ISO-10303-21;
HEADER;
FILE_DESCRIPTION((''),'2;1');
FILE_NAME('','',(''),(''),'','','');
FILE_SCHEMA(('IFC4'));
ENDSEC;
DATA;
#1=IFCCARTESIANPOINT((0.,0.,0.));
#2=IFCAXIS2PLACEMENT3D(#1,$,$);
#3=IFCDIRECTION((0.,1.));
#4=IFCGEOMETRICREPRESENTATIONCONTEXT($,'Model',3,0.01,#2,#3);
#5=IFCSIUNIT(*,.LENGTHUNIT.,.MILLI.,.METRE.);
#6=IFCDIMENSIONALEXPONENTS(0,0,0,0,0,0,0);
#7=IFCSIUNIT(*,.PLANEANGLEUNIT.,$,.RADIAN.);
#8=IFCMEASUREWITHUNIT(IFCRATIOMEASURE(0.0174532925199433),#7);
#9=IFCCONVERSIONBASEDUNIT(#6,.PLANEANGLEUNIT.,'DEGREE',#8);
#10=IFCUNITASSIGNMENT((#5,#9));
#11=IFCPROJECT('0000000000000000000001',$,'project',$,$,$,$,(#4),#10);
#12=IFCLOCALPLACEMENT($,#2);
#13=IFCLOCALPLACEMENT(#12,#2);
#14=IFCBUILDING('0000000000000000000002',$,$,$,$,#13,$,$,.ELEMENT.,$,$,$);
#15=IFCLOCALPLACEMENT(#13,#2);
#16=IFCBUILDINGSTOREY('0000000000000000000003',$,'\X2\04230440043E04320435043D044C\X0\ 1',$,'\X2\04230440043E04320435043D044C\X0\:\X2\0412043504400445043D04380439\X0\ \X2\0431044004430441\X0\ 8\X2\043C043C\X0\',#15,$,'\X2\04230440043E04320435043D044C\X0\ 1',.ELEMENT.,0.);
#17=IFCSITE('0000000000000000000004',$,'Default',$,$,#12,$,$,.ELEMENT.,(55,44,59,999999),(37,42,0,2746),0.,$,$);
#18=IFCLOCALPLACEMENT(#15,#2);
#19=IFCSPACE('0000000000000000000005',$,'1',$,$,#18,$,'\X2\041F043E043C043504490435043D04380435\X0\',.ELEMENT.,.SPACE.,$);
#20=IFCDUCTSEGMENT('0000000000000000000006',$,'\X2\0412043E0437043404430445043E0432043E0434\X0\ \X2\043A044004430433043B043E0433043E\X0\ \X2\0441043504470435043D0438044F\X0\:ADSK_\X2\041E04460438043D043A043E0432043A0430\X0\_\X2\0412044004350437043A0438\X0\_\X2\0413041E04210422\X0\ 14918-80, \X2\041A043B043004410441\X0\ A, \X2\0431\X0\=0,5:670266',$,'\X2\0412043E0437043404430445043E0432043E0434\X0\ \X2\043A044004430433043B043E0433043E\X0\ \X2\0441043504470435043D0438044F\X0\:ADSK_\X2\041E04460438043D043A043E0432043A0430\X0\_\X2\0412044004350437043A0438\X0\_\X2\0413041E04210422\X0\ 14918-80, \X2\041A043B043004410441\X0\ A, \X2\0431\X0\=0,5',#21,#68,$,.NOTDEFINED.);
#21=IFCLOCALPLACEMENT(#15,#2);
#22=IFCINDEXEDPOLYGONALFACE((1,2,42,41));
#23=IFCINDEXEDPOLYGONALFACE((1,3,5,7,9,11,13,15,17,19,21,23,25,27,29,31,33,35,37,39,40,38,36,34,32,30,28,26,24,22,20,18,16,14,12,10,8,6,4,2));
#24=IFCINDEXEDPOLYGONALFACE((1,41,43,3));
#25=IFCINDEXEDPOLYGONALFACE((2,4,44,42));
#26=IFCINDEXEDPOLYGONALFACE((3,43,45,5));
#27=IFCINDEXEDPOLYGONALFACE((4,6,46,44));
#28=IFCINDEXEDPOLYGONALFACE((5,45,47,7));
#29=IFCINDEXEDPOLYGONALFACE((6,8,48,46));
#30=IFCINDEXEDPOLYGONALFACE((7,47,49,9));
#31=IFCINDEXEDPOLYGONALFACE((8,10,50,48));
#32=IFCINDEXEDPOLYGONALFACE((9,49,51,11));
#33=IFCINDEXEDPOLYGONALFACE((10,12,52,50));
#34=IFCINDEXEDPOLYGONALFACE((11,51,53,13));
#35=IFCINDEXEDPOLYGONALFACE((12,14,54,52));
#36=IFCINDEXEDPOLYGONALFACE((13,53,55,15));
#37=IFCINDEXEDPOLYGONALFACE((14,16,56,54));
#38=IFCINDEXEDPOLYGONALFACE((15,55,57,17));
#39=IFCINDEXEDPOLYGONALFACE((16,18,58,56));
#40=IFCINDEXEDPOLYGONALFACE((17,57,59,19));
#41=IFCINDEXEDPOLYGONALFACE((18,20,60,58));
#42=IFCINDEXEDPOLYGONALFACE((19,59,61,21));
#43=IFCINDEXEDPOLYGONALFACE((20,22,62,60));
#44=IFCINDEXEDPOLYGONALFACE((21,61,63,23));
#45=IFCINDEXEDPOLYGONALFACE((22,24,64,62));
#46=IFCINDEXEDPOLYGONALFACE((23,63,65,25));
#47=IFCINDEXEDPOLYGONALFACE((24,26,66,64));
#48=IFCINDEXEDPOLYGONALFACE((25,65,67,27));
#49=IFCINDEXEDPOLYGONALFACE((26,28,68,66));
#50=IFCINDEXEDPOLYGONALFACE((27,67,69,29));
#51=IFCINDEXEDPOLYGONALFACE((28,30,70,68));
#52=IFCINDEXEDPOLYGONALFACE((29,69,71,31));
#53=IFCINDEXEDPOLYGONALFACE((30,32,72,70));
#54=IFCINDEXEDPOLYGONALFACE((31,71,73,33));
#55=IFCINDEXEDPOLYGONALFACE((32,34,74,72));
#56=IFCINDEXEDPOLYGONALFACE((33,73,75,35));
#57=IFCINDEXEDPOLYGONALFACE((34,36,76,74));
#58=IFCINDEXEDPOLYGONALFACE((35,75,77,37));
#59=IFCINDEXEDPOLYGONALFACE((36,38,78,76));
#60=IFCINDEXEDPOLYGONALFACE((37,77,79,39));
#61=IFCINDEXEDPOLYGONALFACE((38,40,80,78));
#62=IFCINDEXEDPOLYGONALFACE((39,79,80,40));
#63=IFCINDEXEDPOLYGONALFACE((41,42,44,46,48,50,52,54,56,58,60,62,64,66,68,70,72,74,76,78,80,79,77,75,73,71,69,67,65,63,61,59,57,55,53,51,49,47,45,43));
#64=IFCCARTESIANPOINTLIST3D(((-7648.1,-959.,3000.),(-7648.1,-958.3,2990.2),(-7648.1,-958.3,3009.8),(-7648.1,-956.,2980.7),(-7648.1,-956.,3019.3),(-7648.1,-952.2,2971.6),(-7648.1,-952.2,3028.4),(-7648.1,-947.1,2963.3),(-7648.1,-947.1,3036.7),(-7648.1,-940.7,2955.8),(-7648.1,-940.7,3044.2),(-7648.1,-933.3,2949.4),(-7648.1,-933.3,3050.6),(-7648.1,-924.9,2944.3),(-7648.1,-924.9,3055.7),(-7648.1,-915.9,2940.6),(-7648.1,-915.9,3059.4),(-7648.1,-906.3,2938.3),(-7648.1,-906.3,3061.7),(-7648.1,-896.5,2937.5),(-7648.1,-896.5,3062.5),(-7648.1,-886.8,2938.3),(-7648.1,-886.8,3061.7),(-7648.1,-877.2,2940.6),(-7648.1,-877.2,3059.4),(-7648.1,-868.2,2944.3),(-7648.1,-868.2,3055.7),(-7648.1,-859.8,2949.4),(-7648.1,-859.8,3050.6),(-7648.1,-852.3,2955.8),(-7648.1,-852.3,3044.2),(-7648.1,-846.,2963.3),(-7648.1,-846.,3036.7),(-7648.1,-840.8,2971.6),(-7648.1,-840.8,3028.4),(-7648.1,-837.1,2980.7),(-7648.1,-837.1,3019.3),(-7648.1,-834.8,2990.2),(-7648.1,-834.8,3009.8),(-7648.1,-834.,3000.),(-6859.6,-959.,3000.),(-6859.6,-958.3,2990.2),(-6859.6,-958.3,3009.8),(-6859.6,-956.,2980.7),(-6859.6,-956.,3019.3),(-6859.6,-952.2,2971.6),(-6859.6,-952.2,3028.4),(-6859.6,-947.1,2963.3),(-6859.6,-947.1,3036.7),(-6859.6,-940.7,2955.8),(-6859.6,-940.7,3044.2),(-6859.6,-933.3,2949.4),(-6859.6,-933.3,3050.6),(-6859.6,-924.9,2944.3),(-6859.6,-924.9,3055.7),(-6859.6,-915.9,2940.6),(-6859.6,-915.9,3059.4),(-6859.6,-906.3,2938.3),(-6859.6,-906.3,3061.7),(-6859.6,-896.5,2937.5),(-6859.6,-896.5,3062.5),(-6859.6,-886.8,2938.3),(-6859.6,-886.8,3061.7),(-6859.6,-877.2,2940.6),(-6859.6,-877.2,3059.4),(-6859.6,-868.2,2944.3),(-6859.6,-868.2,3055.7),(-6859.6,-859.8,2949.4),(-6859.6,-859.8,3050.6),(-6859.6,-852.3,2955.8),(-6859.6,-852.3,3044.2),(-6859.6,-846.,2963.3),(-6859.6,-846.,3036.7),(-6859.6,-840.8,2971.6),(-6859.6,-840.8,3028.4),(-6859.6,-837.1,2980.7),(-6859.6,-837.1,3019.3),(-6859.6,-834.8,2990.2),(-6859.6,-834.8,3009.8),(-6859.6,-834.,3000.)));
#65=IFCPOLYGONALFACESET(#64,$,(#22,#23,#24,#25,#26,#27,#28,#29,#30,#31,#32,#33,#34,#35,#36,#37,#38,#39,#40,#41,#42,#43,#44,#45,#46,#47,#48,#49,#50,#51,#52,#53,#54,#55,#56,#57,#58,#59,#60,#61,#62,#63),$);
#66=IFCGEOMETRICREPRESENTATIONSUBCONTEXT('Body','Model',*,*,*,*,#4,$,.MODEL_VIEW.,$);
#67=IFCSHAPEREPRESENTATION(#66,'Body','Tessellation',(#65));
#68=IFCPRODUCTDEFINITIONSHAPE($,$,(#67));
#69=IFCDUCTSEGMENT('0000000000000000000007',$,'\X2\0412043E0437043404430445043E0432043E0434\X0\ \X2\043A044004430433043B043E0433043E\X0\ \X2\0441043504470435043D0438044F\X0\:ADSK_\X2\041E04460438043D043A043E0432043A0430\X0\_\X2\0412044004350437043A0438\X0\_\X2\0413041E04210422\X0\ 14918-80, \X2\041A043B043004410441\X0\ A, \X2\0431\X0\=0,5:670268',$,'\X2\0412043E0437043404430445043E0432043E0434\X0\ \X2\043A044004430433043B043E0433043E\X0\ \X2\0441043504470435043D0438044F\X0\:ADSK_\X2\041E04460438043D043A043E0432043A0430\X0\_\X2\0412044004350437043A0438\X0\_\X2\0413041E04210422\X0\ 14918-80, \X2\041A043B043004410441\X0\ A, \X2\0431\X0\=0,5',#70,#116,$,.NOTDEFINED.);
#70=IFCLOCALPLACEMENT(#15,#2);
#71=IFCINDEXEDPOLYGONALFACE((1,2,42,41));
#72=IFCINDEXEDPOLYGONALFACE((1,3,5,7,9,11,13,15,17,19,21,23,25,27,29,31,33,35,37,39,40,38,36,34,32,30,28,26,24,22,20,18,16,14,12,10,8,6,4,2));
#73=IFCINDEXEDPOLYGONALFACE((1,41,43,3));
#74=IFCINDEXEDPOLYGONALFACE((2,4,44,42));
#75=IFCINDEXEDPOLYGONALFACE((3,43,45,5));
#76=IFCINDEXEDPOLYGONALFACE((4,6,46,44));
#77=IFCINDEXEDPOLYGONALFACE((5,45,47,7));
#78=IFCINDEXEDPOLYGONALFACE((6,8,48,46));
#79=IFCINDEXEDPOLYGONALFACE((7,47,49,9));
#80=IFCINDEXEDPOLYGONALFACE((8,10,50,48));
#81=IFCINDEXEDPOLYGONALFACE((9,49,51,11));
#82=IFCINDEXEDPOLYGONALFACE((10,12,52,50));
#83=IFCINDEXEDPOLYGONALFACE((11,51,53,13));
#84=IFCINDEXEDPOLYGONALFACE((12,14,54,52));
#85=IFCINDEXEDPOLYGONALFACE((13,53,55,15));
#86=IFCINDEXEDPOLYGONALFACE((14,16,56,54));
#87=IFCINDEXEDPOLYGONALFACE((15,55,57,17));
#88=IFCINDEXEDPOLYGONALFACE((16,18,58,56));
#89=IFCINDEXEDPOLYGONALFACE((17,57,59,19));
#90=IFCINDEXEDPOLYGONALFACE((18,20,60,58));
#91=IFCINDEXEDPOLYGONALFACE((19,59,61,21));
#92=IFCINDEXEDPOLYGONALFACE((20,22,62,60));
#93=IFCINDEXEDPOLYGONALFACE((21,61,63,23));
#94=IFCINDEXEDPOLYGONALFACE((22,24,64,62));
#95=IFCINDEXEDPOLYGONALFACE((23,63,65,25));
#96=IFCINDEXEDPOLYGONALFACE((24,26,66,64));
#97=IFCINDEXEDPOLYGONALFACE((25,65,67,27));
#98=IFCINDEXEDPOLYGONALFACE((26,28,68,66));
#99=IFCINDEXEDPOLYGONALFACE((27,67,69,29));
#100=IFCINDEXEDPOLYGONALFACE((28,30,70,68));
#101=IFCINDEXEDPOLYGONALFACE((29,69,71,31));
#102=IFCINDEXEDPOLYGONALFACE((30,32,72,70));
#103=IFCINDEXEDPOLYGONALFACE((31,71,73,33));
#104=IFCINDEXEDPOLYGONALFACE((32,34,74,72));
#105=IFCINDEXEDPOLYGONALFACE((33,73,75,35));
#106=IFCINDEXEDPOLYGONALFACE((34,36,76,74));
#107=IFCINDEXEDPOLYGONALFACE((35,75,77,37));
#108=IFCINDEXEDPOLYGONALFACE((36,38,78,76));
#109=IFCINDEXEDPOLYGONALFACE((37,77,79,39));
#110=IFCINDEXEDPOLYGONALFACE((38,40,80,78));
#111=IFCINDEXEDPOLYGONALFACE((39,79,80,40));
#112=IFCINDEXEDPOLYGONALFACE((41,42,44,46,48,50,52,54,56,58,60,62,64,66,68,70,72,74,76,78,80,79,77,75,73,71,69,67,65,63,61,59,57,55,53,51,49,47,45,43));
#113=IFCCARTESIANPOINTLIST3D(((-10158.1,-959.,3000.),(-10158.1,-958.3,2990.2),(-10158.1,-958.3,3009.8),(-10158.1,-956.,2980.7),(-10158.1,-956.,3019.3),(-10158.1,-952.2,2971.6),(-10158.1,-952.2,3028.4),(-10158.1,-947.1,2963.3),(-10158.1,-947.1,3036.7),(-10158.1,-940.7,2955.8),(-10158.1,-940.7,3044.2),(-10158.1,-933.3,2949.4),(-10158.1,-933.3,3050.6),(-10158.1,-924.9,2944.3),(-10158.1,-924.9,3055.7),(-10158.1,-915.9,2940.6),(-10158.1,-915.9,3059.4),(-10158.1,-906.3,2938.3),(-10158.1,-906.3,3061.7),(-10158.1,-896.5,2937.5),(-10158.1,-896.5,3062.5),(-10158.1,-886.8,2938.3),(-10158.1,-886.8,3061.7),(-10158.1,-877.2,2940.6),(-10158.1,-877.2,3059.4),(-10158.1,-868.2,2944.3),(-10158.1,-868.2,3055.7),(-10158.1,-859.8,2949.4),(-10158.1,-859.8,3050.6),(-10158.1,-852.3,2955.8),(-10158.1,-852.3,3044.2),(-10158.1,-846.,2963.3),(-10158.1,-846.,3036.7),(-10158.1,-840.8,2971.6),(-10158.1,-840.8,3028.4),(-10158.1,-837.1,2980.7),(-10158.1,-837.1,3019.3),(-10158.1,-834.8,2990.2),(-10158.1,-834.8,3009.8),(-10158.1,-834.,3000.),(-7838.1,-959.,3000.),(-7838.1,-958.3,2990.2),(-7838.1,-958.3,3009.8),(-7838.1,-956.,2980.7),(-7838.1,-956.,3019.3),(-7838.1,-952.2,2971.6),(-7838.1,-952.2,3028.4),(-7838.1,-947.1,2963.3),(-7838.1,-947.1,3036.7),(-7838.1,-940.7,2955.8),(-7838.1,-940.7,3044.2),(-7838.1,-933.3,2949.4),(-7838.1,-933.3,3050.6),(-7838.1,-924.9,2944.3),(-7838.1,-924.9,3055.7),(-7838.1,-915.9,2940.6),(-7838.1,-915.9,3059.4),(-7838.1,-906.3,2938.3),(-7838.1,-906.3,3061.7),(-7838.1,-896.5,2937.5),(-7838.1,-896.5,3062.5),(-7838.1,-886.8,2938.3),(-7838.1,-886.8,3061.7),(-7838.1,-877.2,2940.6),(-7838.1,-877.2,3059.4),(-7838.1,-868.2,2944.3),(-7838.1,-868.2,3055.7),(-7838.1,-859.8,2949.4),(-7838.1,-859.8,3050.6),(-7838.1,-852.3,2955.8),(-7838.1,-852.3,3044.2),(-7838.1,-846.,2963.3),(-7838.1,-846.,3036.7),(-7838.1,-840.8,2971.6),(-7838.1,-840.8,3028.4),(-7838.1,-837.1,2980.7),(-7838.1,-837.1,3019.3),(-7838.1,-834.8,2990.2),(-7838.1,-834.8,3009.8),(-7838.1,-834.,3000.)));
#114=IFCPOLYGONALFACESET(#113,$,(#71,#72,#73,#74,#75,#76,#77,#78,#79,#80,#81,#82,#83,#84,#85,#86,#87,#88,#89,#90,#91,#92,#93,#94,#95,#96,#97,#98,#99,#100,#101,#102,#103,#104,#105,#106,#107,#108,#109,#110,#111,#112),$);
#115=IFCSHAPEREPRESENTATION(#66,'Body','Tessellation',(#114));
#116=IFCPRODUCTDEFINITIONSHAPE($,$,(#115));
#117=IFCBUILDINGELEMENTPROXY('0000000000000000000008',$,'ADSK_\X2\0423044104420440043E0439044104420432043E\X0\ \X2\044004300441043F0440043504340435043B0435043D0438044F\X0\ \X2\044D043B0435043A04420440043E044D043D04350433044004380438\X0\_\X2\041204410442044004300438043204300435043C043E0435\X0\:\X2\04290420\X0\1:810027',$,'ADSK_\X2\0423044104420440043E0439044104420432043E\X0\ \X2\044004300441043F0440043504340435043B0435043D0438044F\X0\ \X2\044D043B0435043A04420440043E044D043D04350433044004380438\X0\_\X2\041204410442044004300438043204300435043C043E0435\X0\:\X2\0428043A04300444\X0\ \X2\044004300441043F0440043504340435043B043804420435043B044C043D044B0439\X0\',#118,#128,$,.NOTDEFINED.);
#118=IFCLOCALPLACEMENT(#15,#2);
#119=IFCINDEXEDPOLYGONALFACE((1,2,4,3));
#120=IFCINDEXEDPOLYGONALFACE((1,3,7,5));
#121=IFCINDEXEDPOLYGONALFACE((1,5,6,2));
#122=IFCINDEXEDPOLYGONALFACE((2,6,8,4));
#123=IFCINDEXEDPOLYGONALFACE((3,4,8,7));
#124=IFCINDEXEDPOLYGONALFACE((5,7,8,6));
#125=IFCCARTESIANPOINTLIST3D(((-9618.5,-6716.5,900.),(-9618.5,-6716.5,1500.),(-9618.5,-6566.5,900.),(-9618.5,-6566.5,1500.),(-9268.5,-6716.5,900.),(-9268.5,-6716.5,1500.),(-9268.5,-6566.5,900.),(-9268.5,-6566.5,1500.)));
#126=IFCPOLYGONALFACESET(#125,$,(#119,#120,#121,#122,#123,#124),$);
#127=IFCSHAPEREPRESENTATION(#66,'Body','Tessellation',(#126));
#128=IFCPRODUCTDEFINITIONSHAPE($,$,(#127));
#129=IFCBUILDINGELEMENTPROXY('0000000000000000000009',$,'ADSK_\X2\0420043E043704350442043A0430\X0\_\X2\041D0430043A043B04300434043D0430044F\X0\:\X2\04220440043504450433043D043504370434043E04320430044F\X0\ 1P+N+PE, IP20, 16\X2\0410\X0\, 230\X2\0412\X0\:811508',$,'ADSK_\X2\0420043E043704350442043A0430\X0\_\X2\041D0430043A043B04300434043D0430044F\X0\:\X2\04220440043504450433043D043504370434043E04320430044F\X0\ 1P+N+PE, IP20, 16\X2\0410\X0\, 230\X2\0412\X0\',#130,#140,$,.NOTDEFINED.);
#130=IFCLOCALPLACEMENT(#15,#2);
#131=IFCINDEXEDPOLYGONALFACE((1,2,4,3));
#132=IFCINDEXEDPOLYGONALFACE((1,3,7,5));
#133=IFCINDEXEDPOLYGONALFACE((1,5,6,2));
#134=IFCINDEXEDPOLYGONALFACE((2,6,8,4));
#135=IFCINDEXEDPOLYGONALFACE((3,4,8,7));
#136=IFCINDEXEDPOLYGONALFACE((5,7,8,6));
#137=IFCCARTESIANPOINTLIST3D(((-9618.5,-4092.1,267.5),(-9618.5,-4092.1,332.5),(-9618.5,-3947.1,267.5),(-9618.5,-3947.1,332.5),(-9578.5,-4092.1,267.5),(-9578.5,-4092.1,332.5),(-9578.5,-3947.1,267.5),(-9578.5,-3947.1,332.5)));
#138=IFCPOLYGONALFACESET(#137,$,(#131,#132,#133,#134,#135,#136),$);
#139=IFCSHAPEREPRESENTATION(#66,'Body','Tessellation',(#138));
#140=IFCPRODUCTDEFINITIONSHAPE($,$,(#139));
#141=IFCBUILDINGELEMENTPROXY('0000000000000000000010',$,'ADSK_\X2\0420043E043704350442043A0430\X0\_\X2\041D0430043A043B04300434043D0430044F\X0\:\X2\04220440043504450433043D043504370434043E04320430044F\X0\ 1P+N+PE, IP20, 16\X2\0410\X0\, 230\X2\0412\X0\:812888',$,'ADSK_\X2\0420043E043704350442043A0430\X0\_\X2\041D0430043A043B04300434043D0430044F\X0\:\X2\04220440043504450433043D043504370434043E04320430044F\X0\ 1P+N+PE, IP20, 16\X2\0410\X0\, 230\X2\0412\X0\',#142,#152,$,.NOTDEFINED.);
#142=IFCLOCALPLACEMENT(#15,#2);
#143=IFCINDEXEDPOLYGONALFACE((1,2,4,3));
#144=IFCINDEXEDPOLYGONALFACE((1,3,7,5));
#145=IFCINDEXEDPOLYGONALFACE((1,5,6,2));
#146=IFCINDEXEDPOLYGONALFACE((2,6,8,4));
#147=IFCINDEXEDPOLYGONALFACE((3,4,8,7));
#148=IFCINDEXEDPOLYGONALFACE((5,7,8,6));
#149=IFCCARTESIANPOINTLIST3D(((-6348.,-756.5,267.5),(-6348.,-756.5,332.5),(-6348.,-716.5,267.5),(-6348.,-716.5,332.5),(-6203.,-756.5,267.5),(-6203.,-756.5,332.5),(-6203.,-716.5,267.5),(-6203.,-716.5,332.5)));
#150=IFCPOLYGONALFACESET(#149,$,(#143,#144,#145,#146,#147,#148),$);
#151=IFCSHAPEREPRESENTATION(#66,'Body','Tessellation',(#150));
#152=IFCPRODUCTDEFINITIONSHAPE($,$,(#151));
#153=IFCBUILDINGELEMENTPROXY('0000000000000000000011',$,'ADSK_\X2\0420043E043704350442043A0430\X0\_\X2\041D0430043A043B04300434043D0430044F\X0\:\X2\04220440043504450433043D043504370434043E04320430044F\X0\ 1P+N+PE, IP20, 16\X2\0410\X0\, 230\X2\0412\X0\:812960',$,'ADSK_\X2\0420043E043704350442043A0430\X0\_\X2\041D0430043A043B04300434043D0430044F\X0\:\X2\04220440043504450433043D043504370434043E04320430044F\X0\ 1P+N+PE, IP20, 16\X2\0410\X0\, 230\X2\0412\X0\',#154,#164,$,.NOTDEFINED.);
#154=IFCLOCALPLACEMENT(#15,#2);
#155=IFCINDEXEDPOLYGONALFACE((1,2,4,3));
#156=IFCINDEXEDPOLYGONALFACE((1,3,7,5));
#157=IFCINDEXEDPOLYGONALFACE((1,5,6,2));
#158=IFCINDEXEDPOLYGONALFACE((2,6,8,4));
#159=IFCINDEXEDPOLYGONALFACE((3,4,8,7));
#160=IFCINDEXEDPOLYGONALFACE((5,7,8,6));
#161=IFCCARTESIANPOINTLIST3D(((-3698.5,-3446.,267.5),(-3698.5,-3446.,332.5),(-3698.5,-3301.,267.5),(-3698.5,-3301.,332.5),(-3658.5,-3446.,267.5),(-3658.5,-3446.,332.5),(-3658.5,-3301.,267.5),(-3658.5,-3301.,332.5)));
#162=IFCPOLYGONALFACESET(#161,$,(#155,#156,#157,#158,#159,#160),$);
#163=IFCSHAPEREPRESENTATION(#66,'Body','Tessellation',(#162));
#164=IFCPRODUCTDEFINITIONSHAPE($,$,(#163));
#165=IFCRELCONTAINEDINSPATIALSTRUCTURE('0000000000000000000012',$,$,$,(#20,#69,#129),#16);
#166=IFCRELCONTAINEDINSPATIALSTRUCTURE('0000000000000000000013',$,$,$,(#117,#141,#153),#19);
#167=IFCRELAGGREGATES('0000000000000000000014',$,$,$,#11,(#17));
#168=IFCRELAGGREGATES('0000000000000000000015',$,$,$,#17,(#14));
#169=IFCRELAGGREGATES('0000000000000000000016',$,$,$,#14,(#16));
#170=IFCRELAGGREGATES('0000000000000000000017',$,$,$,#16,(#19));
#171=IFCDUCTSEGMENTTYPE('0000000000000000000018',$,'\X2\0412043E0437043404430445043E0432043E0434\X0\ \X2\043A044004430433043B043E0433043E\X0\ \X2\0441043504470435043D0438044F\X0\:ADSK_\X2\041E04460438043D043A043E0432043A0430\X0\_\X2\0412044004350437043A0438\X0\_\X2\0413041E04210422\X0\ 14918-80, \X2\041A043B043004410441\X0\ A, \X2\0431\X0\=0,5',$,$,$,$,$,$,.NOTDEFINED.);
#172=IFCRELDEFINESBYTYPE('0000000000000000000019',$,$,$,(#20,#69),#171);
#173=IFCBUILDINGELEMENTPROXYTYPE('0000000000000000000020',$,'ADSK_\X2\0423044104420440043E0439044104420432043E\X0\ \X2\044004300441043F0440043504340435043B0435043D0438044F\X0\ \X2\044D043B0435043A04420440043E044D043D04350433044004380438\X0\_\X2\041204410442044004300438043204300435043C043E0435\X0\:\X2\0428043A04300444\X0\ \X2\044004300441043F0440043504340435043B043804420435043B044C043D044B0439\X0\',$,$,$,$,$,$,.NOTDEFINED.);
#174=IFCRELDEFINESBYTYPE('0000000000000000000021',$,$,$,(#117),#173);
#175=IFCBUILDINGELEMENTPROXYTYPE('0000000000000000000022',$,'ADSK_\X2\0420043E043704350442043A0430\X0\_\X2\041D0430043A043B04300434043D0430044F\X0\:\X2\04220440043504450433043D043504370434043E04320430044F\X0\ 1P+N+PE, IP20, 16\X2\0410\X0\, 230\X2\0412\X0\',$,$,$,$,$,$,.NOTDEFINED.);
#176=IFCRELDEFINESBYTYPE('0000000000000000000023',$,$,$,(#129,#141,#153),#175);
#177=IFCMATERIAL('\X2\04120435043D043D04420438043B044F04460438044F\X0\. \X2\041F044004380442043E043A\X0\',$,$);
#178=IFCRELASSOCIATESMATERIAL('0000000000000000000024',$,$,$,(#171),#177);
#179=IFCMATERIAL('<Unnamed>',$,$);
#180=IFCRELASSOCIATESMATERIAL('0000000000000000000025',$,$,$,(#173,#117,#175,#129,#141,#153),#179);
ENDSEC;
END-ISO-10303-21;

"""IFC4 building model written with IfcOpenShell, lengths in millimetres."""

from ifc_helpers import new_model, entity, si_unit, converted_unit, direction, frame, origin, place, context, subcontext, project, spatial, indexed_curve, outline, extrude, source, transform, mapped, material, type_object, type_shapes, element, save


model = new_model("IFC4")

# Units and contexts
model_context = context("Model", 3, precision=0.01, world=origin(), true_north=direction((0.0, 1.0)))
body_context = subcontext(model_context, "Body", "Model", "MODEL_VIEW")
ifc_project = project(units=[si_unit("LENGTHUNIT", "METRE", prefix="MILLI"), converted_unit("PLANEANGLEUNIT", "DEGREE", entity("IfcRatioMeasure", 0.0174532925199433), si_unit("PLANEANGLEUNIT", "RADIAN"), dimensions=[0, 0, 0, 0, 0, 0, 0])], contexts=[model_context])

# Site, building, storey
site_placement = place(None, origin())
site = spatial("IfcSite", under=ifc_project, at=site_placement, Name="Default", CompositionType="ELEMENT", RefLatitude=(55, 44, 59, 999999), RefLongitude=(37, 42, 0, 2746), RefElevation=0.0)
building_placement = place(site_placement, origin())
building = spatial("IfcBuilding", under=site, at=building_placement, CompositionType="ELEMENT")
storey_placement = place(building_placement, origin())
storey = spatial("IfcBuildingStorey", under=building, at=storey_placement, Name="Уровень 1", ObjectType="Уровень:Верхний брус 8мм", LongName="Уровень 1", CompositionType="ELEMENT", Elevation=0.0)

# Duct segments
ifc_material_1 = material(Name="Веннтиляция. Приток")
duct_segment_type = type_object("IfcDuctSegmentType", Name="Воздуховод круглого сечения:ADSK_Оцинковка_Врезки_ГОСТ 14918-80, Класс A, б=0,5", PredefinedType="NOTDEFINED", material=ifc_material_1)
duct_segment_1_placement = place(storey_placement, origin())
element("IfcDuctSegment", 1, at=duct_segment_1_placement, inside=storey, type_object=duct_segment_type, Name="Воздуховод круглого сечения:ADSK_Оцинковка_Врезки_ГОСТ 14918-80, Класс A, б=0,5:670266", ObjectType="Воздуховод круглого сечения:ADSK_Оцинковка_Врезки_ГОСТ 14918-80, Класс A, б=0,5", PredefinedType="NOTDEFINED", context=body_context, shape_type="SweptSolid", body=[
    extrude(outline(indexed_curve([(62.5, 0.0), (61.7, 9.8), (59.4, 19.3), (55.7, 28.4), (50.6, 36.7), (44.2, 44.2), (36.7, 50.6), (28.4, 55.7), (19.3, 59.4), (9.8, 61.7), (0.0, 62.5), (-9.8, 61.7), (-19.3, 59.4), (-28.4, 55.7), (-36.7, 50.6), (-44.2, 44.2), (-50.6, 36.7), (-55.7, 28.4), (-59.4, 19.3), (-61.7, 9.8), (-62.5, 0.0), (-61.7, -9.8), (-59.4, -19.3), (-55.7, -28.4), (-50.6, -36.7), (-44.2, -44.2), (-36.7, -50.6), (-28.4, -55.7), (-19.3, -59.4), (-9.8, -61.7), (0.0, -62.5), (9.8, -61.7), (19.3, -59.4), (28.4, -55.7), (36.7, -50.6), (44.2, -44.2), (50.6, -36.7), (55.7, -28.4), (59.4, -19.3), (61.7, -9.8), (62.5, 0.0)], self_intersect=False)), frame((-7648.1, -896.5, 3000.0), z_axis=(1.0, 0.0, 0.0), x_axis=(0.0, 1.0, 0.0)), (0.0, 0.0, 1.0), 788.5),
])
duct_segment_2_placement = place(storey_placement, origin())
element("IfcDuctSegment", 2, at=duct_segment_2_placement, inside=storey, type_object=duct_segment_type, Name="Воздуховод круглого сечения:ADSK_Оцинковка_Врезки_ГОСТ 14918-80, Класс A, б=0,5:670268", ObjectType="Воздуховод круглого сечения:ADSK_Оцинковка_Врезки_ГОСТ 14918-80, Класс A, б=0,5", PredefinedType="NOTDEFINED", context=body_context, shape_type="SweptSolid", body=[
    extrude(outline(indexed_curve([(62.5, 0.0), (61.7, 9.8), (59.4, 19.3), (55.7, 28.4), (50.6, 36.7), (44.2, 44.2), (36.7, 50.6), (28.4, 55.7), (19.3, 59.4), (9.8, 61.7), (0.0, 62.5), (-9.8, 61.7), (-19.3, 59.4), (-28.4, 55.7), (-36.7, 50.6), (-44.2, 44.2), (-50.6, 36.7), (-55.7, 28.4), (-59.4, 19.3), (-61.7, 9.8), (-62.5, 0.0), (-61.7, -9.8), (-59.4, -19.3), (-55.7, -28.4), (-50.6, -36.7), (-44.2, -44.2), (-36.7, -50.6), (-28.4, -55.7), (-19.3, -59.4), (-9.8, -61.7), (0.0, -62.5), (9.8, -61.7), (19.3, -59.4), (28.4, -55.7), (36.7, -50.6), (44.2, -44.2), (50.6, -36.7), (55.7, -28.4), (59.4, -19.3), (61.7, -9.8), (62.5, 0.0)], self_intersect=False)), frame((-10158.1, -896.5, 3000.0), z_axis=(1.0, 0.0, 0.0), x_axis=(0.0, 1.0, 0.0)), (0.0, 0.0, 1.0), 2320.0),
])

# Shared definitions
space_placement = place(storey_placement, origin())
space = spatial("IfcSpace", under=storey, at=space_placement, Name="1", LongName="Помещение", CompositionType="ELEMENT", PredefinedType="SPACE")

# Building element proxies
ifc_material_2 = material(Name="<Unnamed>")
building_element_proxy_type_1 = type_object("IfcBuildingElementProxyType", Name="ADSK_Устройство распределения электроэнегрии_Встраиваемое:Шкаф распределительный", PredefinedType="NOTDEFINED", material=ifc_material_2)
shared_shape_1 = source(origin(), body_context, "Body", "SweptSolid", [
    extrude(outline(indexed_curve([(-75.0, -175.0), (75.0, -175.0), (75.0, 175.0), (-75.0, 175.0), (-75.0, -175.0)], self_intersect=False)), frame((0.0, -75.0, -600.0), z_axis=(0.0, 0.0, 1.0), x_axis=(0.0, 1.0, 0.0)), (0.0, 0.0, 1.0), 600.0),
])
type_shapes(building_element_proxy_type_1, [shared_shape_1])
proxy_1_placement = place(space_placement, frame((-9443.5, -6566.5, 1500.0)))
element("IfcBuildingElementProxy", 3, at=proxy_1_placement, inside=space, type_object=building_element_proxy_type_1, material=ifc_material_2, Name="ADSK_Устройство распределения электроэнегрии_Встраиваемое:ЩР1:810027", ObjectType="ADSK_Устройство распределения электроэнегрии_Встраиваемое:Шкаф распределительный", PredefinedType="NOTDEFINED", context=body_context, shape_type="MappedRepresentation", body=[
    mapped(shared_shape_1, transform((0.0, 0.0, 0.0), scale=1.0)),
])
building_element_proxy_type_2 = type_object("IfcBuildingElementProxyType", Name="ADSK_Розетка_Накладная:Трехгнездовая 1P+N+PE, IP20, 16А, 230В", PredefinedType="NOTDEFINED", material=ifc_material_2)
shared_shape_2 = source(origin(), body_context, "Body", "SweptSolid", [
    extrude(outline(indexed_curve([(-72.5, -20.0), (72.5, -20.0), (72.5, 20.0), (-72.5, 20.0), (-72.5, -20.0)], self_intersect=False)), frame((0.0, 20.0, -32.5), z_axis=(0.0, 0.0, 1.0), x_axis=(-1.0, 0.0, 0.0)), (0.0, 0.0, 1.0), 65.0),
])
type_shapes(building_element_proxy_type_2, [shared_shape_2])
proxy_2_placement = place(storey_placement, frame((-9578.5, -4019.6, 300.0), z_axis=(0.0, 0.0, 1.0), x_axis=(0.0, 1.0, 0.0)))
element("IfcBuildingElementProxy", 4, at=proxy_2_placement, inside=storey, type_object=building_element_proxy_type_2, material=ifc_material_2, Name="ADSK_Розетка_Накладная:Трехгнездовая 1P+N+PE, IP20, 16А, 230В:811508", ObjectType="ADSK_Розетка_Накладная:Трехгнездовая 1P+N+PE, IP20, 16А, 230В", PredefinedType="NOTDEFINED", context=body_context, shape_type="MappedRepresentation", body=[
    mapped(shared_shape_2, transform((0.0, 0.0, 0.0), scale=1.0)),
])
for number, where, z_axis, x_axis, name in (
    (5, (-6275.5, -716.5, 300.0), (0.0, 0.0, 1.0), (-1.0, 0.0, 0.0), "ADSK_Розетка_Накладная:Трехгнездовая 1P+N+PE, IP20, 16А, 230В:812888"),
    (6, (-3698.5, -3373.5, 300.0), (0.0, 0.0, 1.0), (0.0, -1.0, 0.0), "ADSK_Розетка_Накладная:Трехгнездовая 1P+N+PE, IP20, 16А, 230В:812960"),
):
    element("IfcBuildingElementProxy", number, at=place(space_placement, frame(where, z_axis=z_axis, x_axis=x_axis)), inside=space, type_object=building_element_proxy_type_2, material=ifc_material_2, Name=name, ObjectType="ADSK_Розетка_Накладная:Трехгнездовая 1P+N+PE, IP20, 16А, 230В", PredefinedType="NOTDEFINED", context=body_context, shape_type="MappedRepresentation", body=[
        mapped(shared_shape_2, transform((0.0, 0.0, 0.0), scale=1.0)),
    ])

save(model, "model.ifc")
